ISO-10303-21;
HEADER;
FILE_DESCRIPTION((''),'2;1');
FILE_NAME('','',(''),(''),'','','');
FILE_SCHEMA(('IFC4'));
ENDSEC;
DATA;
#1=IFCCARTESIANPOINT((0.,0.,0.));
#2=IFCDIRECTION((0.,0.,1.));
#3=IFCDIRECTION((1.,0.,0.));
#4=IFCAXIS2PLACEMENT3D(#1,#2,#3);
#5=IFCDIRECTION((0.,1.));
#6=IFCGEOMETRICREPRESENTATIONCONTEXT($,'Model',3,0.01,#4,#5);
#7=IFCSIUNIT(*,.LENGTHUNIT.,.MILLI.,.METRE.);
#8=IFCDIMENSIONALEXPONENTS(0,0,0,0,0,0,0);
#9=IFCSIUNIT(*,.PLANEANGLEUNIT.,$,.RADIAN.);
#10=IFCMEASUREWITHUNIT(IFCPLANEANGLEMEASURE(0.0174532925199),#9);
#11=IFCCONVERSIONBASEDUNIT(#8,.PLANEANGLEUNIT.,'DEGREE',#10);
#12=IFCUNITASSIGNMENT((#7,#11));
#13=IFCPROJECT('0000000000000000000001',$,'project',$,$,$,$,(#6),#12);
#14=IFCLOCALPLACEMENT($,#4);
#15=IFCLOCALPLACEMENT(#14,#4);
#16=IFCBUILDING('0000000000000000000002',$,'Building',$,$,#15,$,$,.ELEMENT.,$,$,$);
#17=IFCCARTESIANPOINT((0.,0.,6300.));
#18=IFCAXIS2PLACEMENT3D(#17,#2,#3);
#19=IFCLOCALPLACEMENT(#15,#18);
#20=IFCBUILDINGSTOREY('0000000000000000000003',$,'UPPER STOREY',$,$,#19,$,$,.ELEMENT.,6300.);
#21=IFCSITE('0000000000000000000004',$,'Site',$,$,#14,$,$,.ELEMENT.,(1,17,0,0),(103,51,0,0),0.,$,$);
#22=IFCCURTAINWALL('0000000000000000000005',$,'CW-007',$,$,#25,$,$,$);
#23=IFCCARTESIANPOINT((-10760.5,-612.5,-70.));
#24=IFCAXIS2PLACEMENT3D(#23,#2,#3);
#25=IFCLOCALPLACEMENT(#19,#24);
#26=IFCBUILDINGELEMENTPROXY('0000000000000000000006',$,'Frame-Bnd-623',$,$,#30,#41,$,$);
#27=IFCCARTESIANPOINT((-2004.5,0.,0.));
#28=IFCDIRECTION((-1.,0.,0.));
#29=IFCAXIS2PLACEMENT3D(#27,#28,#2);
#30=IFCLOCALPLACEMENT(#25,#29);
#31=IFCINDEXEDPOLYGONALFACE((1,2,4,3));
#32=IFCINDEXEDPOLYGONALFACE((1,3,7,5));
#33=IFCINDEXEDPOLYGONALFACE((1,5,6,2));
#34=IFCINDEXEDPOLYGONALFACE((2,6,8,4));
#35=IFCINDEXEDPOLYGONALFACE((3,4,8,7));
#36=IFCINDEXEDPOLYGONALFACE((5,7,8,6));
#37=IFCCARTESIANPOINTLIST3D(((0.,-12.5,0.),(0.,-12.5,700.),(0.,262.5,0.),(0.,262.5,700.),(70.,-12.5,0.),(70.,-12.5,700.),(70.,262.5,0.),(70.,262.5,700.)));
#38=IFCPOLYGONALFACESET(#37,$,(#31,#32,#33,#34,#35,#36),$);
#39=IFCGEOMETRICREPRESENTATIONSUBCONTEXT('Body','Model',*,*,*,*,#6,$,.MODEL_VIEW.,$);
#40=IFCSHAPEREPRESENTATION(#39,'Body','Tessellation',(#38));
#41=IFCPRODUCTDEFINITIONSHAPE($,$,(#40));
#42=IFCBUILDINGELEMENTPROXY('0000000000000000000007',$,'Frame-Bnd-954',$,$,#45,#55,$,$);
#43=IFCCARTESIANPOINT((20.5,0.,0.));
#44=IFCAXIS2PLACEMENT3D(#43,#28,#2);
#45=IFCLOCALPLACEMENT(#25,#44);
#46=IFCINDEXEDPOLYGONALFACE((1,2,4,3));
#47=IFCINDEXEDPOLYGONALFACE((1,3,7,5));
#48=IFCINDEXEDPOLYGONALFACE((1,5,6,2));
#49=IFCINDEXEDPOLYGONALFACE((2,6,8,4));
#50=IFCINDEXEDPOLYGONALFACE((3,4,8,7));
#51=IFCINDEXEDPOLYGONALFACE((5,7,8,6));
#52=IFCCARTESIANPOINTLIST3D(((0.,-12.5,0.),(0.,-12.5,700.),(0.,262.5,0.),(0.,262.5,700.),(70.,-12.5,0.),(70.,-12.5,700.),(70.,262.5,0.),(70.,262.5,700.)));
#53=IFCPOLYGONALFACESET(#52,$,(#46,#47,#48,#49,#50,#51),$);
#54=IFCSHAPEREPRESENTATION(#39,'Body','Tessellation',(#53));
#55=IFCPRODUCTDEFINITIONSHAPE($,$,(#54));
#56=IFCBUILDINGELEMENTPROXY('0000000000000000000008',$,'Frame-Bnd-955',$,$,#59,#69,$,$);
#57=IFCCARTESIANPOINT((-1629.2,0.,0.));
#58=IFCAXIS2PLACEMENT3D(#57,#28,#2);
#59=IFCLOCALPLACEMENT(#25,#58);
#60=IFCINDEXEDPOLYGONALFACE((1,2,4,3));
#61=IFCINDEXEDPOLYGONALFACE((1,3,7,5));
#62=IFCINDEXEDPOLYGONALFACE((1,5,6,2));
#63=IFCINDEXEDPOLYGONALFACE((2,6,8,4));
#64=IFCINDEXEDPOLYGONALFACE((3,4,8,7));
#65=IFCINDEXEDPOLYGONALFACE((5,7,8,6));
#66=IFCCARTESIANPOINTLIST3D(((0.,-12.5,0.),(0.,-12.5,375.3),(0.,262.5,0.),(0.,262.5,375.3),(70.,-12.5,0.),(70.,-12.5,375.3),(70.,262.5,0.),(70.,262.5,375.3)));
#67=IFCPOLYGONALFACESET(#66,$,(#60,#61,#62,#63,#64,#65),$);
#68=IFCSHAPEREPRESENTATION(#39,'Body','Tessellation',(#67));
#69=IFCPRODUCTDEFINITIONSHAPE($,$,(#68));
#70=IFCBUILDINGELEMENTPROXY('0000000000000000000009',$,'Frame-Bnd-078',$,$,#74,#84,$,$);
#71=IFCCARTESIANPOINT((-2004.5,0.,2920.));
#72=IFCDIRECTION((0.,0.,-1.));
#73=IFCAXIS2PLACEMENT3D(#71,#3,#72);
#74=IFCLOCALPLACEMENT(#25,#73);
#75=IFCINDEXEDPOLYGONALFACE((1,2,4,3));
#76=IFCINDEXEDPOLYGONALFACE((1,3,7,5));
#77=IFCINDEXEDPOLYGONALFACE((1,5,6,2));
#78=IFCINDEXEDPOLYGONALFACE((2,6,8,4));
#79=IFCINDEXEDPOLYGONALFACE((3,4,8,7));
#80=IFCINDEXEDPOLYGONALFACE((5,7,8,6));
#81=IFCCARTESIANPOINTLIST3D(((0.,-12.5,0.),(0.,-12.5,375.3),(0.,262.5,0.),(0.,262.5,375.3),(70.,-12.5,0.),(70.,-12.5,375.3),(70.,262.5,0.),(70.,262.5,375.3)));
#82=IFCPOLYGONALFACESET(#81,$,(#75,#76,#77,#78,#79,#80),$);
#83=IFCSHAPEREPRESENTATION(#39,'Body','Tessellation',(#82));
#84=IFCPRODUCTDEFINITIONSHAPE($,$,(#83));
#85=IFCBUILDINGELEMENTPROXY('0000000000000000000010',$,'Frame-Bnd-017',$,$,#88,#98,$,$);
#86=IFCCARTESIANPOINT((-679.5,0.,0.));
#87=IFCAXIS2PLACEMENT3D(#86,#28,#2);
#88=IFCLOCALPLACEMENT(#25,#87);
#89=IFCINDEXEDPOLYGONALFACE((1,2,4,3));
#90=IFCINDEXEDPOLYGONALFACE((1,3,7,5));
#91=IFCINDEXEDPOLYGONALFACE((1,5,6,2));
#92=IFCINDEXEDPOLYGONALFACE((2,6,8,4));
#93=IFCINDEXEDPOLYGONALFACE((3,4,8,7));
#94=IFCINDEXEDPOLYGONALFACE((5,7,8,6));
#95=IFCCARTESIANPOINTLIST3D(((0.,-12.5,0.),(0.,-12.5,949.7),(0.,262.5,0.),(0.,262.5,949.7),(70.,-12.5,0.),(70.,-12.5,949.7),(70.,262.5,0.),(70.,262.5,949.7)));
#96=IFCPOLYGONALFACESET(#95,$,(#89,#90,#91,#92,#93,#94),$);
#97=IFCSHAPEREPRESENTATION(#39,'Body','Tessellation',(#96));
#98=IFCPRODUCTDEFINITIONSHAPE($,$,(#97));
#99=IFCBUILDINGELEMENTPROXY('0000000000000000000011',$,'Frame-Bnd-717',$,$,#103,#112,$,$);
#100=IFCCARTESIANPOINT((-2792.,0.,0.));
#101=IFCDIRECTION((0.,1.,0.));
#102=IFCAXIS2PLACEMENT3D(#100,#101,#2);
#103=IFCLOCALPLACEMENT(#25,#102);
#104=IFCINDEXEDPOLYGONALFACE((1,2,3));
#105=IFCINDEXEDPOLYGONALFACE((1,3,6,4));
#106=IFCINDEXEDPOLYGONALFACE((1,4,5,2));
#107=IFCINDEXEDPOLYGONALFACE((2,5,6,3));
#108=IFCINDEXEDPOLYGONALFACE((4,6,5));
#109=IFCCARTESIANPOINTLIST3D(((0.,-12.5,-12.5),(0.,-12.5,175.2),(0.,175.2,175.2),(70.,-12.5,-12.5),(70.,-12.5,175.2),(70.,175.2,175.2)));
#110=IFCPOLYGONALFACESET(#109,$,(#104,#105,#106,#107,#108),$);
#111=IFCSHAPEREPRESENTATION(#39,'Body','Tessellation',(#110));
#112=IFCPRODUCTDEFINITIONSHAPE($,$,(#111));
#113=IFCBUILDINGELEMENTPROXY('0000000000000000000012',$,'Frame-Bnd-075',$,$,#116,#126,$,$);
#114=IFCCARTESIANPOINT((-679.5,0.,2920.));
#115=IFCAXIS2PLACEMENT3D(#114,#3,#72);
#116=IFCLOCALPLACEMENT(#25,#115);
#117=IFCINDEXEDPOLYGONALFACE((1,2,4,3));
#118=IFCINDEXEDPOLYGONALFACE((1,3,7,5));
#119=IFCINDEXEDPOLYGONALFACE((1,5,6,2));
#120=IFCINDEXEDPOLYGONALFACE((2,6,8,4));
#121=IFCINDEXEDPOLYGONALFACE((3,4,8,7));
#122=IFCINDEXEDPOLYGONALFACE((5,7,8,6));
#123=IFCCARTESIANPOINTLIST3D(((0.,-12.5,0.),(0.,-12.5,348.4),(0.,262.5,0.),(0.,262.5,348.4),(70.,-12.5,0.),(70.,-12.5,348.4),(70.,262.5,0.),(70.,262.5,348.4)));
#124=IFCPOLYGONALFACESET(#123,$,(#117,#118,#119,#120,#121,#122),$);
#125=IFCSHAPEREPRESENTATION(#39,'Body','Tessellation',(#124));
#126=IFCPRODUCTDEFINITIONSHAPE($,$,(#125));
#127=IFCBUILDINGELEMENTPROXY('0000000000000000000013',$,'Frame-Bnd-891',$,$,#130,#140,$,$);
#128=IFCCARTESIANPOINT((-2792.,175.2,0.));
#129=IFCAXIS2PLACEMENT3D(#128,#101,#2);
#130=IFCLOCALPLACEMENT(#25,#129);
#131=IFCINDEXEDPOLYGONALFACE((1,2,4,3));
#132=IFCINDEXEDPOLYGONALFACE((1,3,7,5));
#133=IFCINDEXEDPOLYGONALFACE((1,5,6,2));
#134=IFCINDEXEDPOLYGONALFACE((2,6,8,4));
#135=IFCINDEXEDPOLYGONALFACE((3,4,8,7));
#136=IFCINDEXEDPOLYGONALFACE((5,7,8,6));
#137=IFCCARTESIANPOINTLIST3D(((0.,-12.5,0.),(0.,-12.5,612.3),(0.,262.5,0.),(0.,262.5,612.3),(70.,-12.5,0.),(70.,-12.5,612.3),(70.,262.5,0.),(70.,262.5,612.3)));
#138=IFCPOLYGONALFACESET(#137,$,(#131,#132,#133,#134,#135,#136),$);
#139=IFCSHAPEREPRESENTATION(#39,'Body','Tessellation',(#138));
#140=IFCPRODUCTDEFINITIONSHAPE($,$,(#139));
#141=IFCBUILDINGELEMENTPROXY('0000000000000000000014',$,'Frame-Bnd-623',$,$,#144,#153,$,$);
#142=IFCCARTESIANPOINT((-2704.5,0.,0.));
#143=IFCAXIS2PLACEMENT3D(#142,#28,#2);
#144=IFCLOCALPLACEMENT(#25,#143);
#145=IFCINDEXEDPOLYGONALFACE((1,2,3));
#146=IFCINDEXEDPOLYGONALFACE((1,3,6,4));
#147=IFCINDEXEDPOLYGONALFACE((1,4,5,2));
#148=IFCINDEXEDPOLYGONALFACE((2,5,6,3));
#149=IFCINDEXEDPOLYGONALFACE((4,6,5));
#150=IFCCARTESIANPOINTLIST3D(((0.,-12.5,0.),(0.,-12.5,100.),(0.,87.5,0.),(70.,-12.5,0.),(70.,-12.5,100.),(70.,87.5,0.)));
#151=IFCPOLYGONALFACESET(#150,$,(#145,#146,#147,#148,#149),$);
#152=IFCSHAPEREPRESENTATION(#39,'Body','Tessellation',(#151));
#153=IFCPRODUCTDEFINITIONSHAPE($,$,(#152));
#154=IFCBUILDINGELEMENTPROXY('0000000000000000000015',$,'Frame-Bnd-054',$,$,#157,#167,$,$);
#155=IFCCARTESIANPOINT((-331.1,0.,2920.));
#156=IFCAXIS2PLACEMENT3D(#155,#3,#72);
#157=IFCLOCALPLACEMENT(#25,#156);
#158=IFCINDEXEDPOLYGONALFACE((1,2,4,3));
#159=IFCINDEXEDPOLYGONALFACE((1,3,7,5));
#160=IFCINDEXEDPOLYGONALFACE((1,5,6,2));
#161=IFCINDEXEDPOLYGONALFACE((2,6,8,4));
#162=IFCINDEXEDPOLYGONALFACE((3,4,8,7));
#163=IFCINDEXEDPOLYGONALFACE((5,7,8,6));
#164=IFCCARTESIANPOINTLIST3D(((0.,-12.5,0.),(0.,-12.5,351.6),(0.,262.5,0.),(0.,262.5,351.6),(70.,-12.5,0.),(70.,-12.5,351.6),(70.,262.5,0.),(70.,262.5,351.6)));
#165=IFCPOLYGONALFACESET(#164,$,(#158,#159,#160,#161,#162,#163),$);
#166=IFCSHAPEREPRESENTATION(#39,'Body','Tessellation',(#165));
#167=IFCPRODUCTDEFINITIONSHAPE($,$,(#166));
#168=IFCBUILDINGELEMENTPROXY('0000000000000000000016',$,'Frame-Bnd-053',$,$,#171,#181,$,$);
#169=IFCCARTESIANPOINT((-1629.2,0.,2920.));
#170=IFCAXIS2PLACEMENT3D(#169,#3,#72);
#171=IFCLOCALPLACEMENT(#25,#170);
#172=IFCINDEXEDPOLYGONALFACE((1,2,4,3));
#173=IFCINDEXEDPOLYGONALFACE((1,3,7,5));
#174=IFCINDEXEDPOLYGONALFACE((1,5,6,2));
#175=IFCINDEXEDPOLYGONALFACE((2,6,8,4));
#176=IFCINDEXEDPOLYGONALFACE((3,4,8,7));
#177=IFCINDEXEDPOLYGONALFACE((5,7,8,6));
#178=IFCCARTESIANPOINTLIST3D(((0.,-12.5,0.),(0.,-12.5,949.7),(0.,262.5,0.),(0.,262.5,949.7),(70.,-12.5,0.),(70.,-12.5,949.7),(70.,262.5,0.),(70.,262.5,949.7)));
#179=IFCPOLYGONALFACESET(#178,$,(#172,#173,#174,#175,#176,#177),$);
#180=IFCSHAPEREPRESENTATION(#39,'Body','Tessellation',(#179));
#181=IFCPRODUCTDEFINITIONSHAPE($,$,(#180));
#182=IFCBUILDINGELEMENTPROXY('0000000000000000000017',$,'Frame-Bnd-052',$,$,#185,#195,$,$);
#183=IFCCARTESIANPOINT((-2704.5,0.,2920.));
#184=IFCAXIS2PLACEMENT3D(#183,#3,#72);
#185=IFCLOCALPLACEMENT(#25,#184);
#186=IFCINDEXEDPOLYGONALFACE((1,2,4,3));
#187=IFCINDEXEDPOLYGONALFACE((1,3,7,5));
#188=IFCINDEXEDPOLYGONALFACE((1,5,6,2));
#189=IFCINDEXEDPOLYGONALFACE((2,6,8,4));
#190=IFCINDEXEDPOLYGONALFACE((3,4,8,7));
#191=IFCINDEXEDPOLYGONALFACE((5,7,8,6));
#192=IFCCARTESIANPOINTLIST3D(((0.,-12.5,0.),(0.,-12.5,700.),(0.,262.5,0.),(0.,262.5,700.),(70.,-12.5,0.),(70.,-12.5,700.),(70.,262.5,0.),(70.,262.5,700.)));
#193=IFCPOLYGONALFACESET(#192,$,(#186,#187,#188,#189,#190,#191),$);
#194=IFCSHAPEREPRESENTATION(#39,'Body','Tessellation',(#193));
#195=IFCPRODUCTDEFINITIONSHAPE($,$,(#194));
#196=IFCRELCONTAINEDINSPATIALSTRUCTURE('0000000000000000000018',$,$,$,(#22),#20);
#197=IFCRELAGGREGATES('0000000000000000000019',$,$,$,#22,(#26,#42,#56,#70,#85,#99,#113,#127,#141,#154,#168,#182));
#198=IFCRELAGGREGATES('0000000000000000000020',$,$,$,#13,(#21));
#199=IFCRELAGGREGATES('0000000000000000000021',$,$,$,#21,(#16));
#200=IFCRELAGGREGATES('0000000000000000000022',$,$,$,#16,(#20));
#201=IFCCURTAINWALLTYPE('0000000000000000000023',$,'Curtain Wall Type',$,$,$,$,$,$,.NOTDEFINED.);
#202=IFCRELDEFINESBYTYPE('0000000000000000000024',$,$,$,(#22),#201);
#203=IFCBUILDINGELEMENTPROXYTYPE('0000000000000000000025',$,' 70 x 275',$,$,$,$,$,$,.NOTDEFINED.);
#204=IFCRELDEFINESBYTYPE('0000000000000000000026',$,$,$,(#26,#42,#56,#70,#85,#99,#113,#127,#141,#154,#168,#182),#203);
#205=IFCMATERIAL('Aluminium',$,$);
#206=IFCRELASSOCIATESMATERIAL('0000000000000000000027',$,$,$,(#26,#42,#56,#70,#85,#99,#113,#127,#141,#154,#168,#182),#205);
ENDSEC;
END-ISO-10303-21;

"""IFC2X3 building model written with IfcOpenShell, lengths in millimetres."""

from ifc_helpers import new_model, entity, si_unit, converted_unit, direction, frame, origin_with_axes, place, context, subcontext, project, spatial, polyline, outline, extrude, clip, halfspace, material, type_object, element, aggregate, save


model = new_model("IFC2X3")

# Units and contexts
model_context = context("Model", 3, precision=0.01, world=origin_with_axes(), true_north=direction((0.0, 1.0)))
body_context = subcontext(model_context, "Body", "Model", "MODEL_VIEW")
ifc_project = project(units=[si_unit("LENGTHUNIT", "METRE", prefix="MILLI"), converted_unit("PLANEANGLEUNIT", "DEGREE", entity("IfcPlaneAngleMeasure", 0.0174532925199), si_unit("PLANEANGLEUNIT", "RADIAN"), dimensions=[0, 0, 0, 0, 0, 0, 0])], contexts=[model_context])

# Site, building, storey
site_placement = place(None, origin_with_axes())
site = spatial("IfcSite", under=ifc_project, at=site_placement, Name="Site", CompositionType="ELEMENT", RefLatitude=(1, 17, 0, 0), RefLongitude=(103, 51, 0, 0), RefElevation=0.0)
building_placement = place(site_placement, origin_with_axes())
building = spatial("IfcBuilding", under=site, at=building_placement, Name="Building", CompositionType="ELEMENT")
storey_placement = place(building_placement, frame((0.0, 0.0, 6300.0), z_axis=(0.0, 0.0, 1.0), x_axis=(1.0, 0.0, 0.0)))
storey = spatial("IfcBuildingStorey", under=building, at=storey_placement, Name="UPPER STOREY", CompositionType="ELEMENT", Elevation=6300.0)

# Curtain wall, building element proxies
curtain_wall_type = type_object("IfcCurtainWallType", Name="Curtain Wall Type", PredefinedType="NOTDEFINED")
curtain_wall_placement = place(storey_placement, frame((-10760.5, -612.5, -70.0), z_axis=(0.0, 0.0, 1.0), x_axis=(1.0, 0.0, 0.0)))
curtain_wall = element("IfcCurtainWall", 1, at=curtain_wall_placement, inside=storey, type_object=curtain_wall_type, Name="CW-007")
ifc_material_1 = material(Name="Aluminium")
building_element_proxy_type_1 = type_object("IfcBuildingElementProxyType", Name=" 70 x 275", PredefinedType="NOTDEFINED")
proxy_1_placement = place(curtain_wall_placement, frame((-2004.5, 0.0, 0.0), z_axis=(-1.0, 0.0, 0.0), x_axis=(0.0, 0.0, 1.0)))
proxy_1 = element("IfcBuildingElementProxy", 2, at=proxy_1_placement, type_object=building_element_proxy_type_1, material=ifc_material_1, Name="Frame-Bnd-623", context=body_context, shape_type="SweptSolid", body=[
    extrude(outline(polyline([(262.5, -70.0), (262.5, 0.0), (-12.5, 0.0), (-12.5, -70.0), (262.5, -70.0)])), frame((0.0, 0.0, 0.0), z_axis=(0.0, 0.0, 1.0), x_axis=(0.0, 1.0, 0.0)), (0.0, 0.0, 1.0), 700.0),
])
proxy_2_placement = place(curtain_wall_placement, frame((20.5, 0.0, 0.0), z_axis=(-1.0, 0.0, 0.0), x_axis=(0.0, 0.0, 1.0)))
proxy_2 = element("IfcBuildingElementProxy", 3, at=proxy_2_placement, type_object=building_element_proxy_type_1, material=ifc_material_1, Name="Frame-Bnd-954", context=body_context, shape_type="SweptSolid", body=[
    extrude(outline(polyline([(262.5, -70.0), (262.5, 0.0), (-12.5, 0.0), (-12.5, -70.0), (262.5, -70.0)])), frame((0.0, 0.0, 0.0), z_axis=(0.0, 0.0, 1.0), x_axis=(0.0, 1.0, 0.0)), (0.0, 0.0, 1.0), 700.0),
])
proxy_3_placement = place(curtain_wall_placement, frame((-1629.2, 0.0, 0.0), z_axis=(-1.0, 0.0, 0.0), x_axis=(0.0, 0.0, 1.0)))
proxy_3 = element("IfcBuildingElementProxy", 4, at=proxy_3_placement, type_object=building_element_proxy_type_1, material=ifc_material_1, Name="Frame-Bnd-955", context=body_context, shape_type="SweptSolid", body=[
    extrude(outline(polyline([(262.5, -70.0), (262.5, 0.0), (-12.5, 0.0), (-12.5, -70.0), (262.5, -70.0)])), frame((0.0, 0.0, 0.0), z_axis=(0.0, 0.0, 1.0), x_axis=(0.0, 1.0, 0.0)), (0.0, 0.0, 1.0), 375.3),
])
proxy_4_placement = place(curtain_wall_placement, frame((-2004.5, 0.0, 2920.0), z_axis=(1.0, 0.0, 0.0), x_axis=(0.0, 0.0, -1.0)))
proxy_4 = element("IfcBuildingElementProxy", 5, at=proxy_4_placement, type_object=building_element_proxy_type_1, material=ifc_material_1, Name="Frame-Bnd-078", context=body_context, shape_type="SweptSolid", body=[
    extrude(outline(polyline([(-262.5, 70.0), (-262.5, 0.0), (12.5, 0.0), (12.5, 70.0), (-262.5, 70.0)])), frame((0.0, 0.0, 0.0), z_axis=(0.0, 0.0, 1.0), x_axis=(0.0, -1.0, 0.0)), (0.0, 0.0, 1.0), 375.3),
])
proxy_5_placement = place(curtain_wall_placement, frame((-679.5, 0.0, 0.0), z_axis=(-1.0, 0.0, 0.0), x_axis=(0.0, 0.0, 1.0)))
proxy_5 = element("IfcBuildingElementProxy", 6, at=proxy_5_placement, type_object=building_element_proxy_type_1, material=ifc_material_1, Name="Frame-Bnd-017", context=body_context, shape_type="SweptSolid", body=[
    extrude(outline(polyline([(262.5, -70.0), (262.5, 0.0), (-12.5, 0.0), (-12.5, -70.0), (262.5, -70.0)])), frame((0.0, 0.0, 0.0), z_axis=(0.0, 0.0, 1.0), x_axis=(0.0, 1.0, 0.0)), (0.0, 0.0, 1.0), 949.7),
])
proxy_6_placement = place(curtain_wall_placement, frame((-2792.0, 0.0, 0.0), z_axis=(0.0, 1.0, 0.0), x_axis=(0.0, 0.0, 1.0)))
proxy_6 = element("IfcBuildingElementProxy", 7, at=proxy_6_placement, type_object=building_element_proxy_type_1, material=ifc_material_1, Name="Frame-Bnd-717", context=body_context, shape_type="Clipping", body=[
    clip(extrude(outline(polyline([(175.2, -70.0), (175.2, 0.0), (-12.5, 0.0), (-12.5, -70.0), (175.2, -70.0)])), frame((0.0, 0.0, -12.5), z_axis=(0.0, 0.0, 1.0), x_axis=(0.0, 1.0, 0.0)), (0.0, 0.0, 1.0), 187.7), halfspace(frame((0.0, 0.0, 0.0), z_axis=(0.0, -0.707107, 0.707107), x_axis=(0.0, -0.707107, -0.707107)), True)),
])
proxy_7_placement = place(curtain_wall_placement, frame((-679.5, 0.0, 2920.0), z_axis=(1.0, 0.0, 0.0), x_axis=(0.0, 0.0, -1.0)))
proxy_7 = element("IfcBuildingElementProxy", 8, at=proxy_7_placement, type_object=building_element_proxy_type_1, material=ifc_material_1, Name="Frame-Bnd-075", context=body_context, shape_type="SweptSolid", body=[
    extrude(outline(polyline([(-262.5, 70.0), (-262.5, 0.0), (12.5, 0.0), (12.5, 70.0), (-262.5, 70.0)])), frame((0.0, 0.0, 0.0), z_axis=(0.0, 0.0, 1.0), x_axis=(0.0, -1.0, 0.0)), (0.0, 0.0, 1.0), 348.4),
])
proxy_8_placement = place(curtain_wall_placement, frame((-2792.0, 175.2, 0.0), z_axis=(0.0, 1.0, 0.0), x_axis=(0.0, 0.0, 1.0)))
proxy_8 = element("IfcBuildingElementProxy", 9, at=proxy_8_placement, type_object=building_element_proxy_type_1, material=ifc_material_1, Name="Frame-Bnd-891", context=body_context, shape_type="SweptSolid", body=[
    extrude(outline(polyline([(262.5, -70.0), (262.5, 0.0), (-12.5, 0.0), (-12.5, -70.0), (262.5, -70.0)])), frame((0.0, 0.0, 0.0), z_axis=(0.0, 0.0, 1.0), x_axis=(0.0, 1.0, 0.0)), (0.0, 0.0, 1.0), 612.3),
])
proxy_9_placement = place(curtain_wall_placement, frame((-2704.5, 0.0, 0.0), z_axis=(-1.0, 0.0, 0.0), x_axis=(0.0, 0.0, 1.0)))
proxy_9 = element("IfcBuildingElementProxy", 10, at=proxy_9_placement, type_object=building_element_proxy_type_1, material=ifc_material_1, Name="Frame-Bnd-623", context=body_context, shape_type="Clipping", body=[
    clip(extrude(outline(polyline([(87.5, -70.0), (87.5, 0.0), (-12.5, 0.0), (-12.5, -70.0), (87.5, -70.0)])), frame((0.0, 0.0, 0.0), z_axis=(0.0, 0.0, 1.0), x_axis=(0.0, 1.0, 0.0)), (0.0, 0.0, 1.0), 100.0), halfspace(frame((0.0, 43.8, 43.8), z_axis=(0.0, -0.707107, -0.707107), x_axis=(0.0, 0.707107, -0.707107)), True)),
])
proxy_10_placement = place(curtain_wall_placement, frame((-331.1, 0.0, 2920.0), z_axis=(1.0, 0.0, 0.0), x_axis=(0.0, 0.0, -1.0)))
proxy_10 = element("IfcBuildingElementProxy", 11, at=proxy_10_placement, type_object=building_element_proxy_type_1, material=ifc_material_1, Name="Frame-Bnd-054", context=body_context, shape_type="SweptSolid", body=[
    extrude(outline(polyline([(-262.5, 70.0), (-262.5, 0.0), (12.5, 0.0), (12.5, 70.0), (-262.5, 70.0)])), frame((0.0, 0.0, 0.0), z_axis=(0.0, 0.0, 1.0), x_axis=(0.0, -1.0, 0.0)), (0.0, 0.0, 1.0), 351.6),
])
proxy_11_placement = place(curtain_wall_placement, frame((-1629.2, 0.0, 2920.0), z_axis=(1.0, 0.0, 0.0), x_axis=(0.0, 0.0, -1.0)))
proxy_11 = element("IfcBuildingElementProxy", 12, at=proxy_11_placement, type_object=building_element_proxy_type_1, material=ifc_material_1, Name="Frame-Bnd-053", context=body_context, shape_type="SweptSolid", body=[
    extrude(outline(polyline([(-262.5, 70.0), (-262.5, 0.0), (12.5, 0.0), (12.5, 70.0), (-262.5, 70.0)])), frame((0.0, 0.0, 0.0), z_axis=(0.0, 0.0, 1.0), x_axis=(0.0, -1.0, 0.0)), (0.0, 0.0, 1.0), 949.7),
])
proxy_12_placement = place(curtain_wall_placement, frame((-2704.5, 0.0, 2920.0), z_axis=(1.0, 0.0, 0.0), x_axis=(0.0, 0.0, -1.0)))
proxy_12 = element("IfcBuildingElementProxy", 13, at=proxy_12_placement, type_object=building_element_proxy_type_1, material=ifc_material_1, Name="Frame-Bnd-052", context=body_context, shape_type="SweptSolid", body=[
    extrude(outline(polyline([(-262.5, 70.0), (-262.5, 0.0), (12.5, 0.0), (12.5, 70.0), (-262.5, 70.0)])), frame((0.0, 0.0, 0.0), z_axis=(0.0, 0.0, 1.0), x_axis=(0.0, -1.0, 0.0)), (0.0, 0.0, 1.0), 700.0),
])
aggregate(curtain_wall, [proxy_1, proxy_2, proxy_3, proxy_4, proxy_5, proxy_6, proxy_7, proxy_8, proxy_9, proxy_10, proxy_11, proxy_12])

save(model, "model.ifc")
